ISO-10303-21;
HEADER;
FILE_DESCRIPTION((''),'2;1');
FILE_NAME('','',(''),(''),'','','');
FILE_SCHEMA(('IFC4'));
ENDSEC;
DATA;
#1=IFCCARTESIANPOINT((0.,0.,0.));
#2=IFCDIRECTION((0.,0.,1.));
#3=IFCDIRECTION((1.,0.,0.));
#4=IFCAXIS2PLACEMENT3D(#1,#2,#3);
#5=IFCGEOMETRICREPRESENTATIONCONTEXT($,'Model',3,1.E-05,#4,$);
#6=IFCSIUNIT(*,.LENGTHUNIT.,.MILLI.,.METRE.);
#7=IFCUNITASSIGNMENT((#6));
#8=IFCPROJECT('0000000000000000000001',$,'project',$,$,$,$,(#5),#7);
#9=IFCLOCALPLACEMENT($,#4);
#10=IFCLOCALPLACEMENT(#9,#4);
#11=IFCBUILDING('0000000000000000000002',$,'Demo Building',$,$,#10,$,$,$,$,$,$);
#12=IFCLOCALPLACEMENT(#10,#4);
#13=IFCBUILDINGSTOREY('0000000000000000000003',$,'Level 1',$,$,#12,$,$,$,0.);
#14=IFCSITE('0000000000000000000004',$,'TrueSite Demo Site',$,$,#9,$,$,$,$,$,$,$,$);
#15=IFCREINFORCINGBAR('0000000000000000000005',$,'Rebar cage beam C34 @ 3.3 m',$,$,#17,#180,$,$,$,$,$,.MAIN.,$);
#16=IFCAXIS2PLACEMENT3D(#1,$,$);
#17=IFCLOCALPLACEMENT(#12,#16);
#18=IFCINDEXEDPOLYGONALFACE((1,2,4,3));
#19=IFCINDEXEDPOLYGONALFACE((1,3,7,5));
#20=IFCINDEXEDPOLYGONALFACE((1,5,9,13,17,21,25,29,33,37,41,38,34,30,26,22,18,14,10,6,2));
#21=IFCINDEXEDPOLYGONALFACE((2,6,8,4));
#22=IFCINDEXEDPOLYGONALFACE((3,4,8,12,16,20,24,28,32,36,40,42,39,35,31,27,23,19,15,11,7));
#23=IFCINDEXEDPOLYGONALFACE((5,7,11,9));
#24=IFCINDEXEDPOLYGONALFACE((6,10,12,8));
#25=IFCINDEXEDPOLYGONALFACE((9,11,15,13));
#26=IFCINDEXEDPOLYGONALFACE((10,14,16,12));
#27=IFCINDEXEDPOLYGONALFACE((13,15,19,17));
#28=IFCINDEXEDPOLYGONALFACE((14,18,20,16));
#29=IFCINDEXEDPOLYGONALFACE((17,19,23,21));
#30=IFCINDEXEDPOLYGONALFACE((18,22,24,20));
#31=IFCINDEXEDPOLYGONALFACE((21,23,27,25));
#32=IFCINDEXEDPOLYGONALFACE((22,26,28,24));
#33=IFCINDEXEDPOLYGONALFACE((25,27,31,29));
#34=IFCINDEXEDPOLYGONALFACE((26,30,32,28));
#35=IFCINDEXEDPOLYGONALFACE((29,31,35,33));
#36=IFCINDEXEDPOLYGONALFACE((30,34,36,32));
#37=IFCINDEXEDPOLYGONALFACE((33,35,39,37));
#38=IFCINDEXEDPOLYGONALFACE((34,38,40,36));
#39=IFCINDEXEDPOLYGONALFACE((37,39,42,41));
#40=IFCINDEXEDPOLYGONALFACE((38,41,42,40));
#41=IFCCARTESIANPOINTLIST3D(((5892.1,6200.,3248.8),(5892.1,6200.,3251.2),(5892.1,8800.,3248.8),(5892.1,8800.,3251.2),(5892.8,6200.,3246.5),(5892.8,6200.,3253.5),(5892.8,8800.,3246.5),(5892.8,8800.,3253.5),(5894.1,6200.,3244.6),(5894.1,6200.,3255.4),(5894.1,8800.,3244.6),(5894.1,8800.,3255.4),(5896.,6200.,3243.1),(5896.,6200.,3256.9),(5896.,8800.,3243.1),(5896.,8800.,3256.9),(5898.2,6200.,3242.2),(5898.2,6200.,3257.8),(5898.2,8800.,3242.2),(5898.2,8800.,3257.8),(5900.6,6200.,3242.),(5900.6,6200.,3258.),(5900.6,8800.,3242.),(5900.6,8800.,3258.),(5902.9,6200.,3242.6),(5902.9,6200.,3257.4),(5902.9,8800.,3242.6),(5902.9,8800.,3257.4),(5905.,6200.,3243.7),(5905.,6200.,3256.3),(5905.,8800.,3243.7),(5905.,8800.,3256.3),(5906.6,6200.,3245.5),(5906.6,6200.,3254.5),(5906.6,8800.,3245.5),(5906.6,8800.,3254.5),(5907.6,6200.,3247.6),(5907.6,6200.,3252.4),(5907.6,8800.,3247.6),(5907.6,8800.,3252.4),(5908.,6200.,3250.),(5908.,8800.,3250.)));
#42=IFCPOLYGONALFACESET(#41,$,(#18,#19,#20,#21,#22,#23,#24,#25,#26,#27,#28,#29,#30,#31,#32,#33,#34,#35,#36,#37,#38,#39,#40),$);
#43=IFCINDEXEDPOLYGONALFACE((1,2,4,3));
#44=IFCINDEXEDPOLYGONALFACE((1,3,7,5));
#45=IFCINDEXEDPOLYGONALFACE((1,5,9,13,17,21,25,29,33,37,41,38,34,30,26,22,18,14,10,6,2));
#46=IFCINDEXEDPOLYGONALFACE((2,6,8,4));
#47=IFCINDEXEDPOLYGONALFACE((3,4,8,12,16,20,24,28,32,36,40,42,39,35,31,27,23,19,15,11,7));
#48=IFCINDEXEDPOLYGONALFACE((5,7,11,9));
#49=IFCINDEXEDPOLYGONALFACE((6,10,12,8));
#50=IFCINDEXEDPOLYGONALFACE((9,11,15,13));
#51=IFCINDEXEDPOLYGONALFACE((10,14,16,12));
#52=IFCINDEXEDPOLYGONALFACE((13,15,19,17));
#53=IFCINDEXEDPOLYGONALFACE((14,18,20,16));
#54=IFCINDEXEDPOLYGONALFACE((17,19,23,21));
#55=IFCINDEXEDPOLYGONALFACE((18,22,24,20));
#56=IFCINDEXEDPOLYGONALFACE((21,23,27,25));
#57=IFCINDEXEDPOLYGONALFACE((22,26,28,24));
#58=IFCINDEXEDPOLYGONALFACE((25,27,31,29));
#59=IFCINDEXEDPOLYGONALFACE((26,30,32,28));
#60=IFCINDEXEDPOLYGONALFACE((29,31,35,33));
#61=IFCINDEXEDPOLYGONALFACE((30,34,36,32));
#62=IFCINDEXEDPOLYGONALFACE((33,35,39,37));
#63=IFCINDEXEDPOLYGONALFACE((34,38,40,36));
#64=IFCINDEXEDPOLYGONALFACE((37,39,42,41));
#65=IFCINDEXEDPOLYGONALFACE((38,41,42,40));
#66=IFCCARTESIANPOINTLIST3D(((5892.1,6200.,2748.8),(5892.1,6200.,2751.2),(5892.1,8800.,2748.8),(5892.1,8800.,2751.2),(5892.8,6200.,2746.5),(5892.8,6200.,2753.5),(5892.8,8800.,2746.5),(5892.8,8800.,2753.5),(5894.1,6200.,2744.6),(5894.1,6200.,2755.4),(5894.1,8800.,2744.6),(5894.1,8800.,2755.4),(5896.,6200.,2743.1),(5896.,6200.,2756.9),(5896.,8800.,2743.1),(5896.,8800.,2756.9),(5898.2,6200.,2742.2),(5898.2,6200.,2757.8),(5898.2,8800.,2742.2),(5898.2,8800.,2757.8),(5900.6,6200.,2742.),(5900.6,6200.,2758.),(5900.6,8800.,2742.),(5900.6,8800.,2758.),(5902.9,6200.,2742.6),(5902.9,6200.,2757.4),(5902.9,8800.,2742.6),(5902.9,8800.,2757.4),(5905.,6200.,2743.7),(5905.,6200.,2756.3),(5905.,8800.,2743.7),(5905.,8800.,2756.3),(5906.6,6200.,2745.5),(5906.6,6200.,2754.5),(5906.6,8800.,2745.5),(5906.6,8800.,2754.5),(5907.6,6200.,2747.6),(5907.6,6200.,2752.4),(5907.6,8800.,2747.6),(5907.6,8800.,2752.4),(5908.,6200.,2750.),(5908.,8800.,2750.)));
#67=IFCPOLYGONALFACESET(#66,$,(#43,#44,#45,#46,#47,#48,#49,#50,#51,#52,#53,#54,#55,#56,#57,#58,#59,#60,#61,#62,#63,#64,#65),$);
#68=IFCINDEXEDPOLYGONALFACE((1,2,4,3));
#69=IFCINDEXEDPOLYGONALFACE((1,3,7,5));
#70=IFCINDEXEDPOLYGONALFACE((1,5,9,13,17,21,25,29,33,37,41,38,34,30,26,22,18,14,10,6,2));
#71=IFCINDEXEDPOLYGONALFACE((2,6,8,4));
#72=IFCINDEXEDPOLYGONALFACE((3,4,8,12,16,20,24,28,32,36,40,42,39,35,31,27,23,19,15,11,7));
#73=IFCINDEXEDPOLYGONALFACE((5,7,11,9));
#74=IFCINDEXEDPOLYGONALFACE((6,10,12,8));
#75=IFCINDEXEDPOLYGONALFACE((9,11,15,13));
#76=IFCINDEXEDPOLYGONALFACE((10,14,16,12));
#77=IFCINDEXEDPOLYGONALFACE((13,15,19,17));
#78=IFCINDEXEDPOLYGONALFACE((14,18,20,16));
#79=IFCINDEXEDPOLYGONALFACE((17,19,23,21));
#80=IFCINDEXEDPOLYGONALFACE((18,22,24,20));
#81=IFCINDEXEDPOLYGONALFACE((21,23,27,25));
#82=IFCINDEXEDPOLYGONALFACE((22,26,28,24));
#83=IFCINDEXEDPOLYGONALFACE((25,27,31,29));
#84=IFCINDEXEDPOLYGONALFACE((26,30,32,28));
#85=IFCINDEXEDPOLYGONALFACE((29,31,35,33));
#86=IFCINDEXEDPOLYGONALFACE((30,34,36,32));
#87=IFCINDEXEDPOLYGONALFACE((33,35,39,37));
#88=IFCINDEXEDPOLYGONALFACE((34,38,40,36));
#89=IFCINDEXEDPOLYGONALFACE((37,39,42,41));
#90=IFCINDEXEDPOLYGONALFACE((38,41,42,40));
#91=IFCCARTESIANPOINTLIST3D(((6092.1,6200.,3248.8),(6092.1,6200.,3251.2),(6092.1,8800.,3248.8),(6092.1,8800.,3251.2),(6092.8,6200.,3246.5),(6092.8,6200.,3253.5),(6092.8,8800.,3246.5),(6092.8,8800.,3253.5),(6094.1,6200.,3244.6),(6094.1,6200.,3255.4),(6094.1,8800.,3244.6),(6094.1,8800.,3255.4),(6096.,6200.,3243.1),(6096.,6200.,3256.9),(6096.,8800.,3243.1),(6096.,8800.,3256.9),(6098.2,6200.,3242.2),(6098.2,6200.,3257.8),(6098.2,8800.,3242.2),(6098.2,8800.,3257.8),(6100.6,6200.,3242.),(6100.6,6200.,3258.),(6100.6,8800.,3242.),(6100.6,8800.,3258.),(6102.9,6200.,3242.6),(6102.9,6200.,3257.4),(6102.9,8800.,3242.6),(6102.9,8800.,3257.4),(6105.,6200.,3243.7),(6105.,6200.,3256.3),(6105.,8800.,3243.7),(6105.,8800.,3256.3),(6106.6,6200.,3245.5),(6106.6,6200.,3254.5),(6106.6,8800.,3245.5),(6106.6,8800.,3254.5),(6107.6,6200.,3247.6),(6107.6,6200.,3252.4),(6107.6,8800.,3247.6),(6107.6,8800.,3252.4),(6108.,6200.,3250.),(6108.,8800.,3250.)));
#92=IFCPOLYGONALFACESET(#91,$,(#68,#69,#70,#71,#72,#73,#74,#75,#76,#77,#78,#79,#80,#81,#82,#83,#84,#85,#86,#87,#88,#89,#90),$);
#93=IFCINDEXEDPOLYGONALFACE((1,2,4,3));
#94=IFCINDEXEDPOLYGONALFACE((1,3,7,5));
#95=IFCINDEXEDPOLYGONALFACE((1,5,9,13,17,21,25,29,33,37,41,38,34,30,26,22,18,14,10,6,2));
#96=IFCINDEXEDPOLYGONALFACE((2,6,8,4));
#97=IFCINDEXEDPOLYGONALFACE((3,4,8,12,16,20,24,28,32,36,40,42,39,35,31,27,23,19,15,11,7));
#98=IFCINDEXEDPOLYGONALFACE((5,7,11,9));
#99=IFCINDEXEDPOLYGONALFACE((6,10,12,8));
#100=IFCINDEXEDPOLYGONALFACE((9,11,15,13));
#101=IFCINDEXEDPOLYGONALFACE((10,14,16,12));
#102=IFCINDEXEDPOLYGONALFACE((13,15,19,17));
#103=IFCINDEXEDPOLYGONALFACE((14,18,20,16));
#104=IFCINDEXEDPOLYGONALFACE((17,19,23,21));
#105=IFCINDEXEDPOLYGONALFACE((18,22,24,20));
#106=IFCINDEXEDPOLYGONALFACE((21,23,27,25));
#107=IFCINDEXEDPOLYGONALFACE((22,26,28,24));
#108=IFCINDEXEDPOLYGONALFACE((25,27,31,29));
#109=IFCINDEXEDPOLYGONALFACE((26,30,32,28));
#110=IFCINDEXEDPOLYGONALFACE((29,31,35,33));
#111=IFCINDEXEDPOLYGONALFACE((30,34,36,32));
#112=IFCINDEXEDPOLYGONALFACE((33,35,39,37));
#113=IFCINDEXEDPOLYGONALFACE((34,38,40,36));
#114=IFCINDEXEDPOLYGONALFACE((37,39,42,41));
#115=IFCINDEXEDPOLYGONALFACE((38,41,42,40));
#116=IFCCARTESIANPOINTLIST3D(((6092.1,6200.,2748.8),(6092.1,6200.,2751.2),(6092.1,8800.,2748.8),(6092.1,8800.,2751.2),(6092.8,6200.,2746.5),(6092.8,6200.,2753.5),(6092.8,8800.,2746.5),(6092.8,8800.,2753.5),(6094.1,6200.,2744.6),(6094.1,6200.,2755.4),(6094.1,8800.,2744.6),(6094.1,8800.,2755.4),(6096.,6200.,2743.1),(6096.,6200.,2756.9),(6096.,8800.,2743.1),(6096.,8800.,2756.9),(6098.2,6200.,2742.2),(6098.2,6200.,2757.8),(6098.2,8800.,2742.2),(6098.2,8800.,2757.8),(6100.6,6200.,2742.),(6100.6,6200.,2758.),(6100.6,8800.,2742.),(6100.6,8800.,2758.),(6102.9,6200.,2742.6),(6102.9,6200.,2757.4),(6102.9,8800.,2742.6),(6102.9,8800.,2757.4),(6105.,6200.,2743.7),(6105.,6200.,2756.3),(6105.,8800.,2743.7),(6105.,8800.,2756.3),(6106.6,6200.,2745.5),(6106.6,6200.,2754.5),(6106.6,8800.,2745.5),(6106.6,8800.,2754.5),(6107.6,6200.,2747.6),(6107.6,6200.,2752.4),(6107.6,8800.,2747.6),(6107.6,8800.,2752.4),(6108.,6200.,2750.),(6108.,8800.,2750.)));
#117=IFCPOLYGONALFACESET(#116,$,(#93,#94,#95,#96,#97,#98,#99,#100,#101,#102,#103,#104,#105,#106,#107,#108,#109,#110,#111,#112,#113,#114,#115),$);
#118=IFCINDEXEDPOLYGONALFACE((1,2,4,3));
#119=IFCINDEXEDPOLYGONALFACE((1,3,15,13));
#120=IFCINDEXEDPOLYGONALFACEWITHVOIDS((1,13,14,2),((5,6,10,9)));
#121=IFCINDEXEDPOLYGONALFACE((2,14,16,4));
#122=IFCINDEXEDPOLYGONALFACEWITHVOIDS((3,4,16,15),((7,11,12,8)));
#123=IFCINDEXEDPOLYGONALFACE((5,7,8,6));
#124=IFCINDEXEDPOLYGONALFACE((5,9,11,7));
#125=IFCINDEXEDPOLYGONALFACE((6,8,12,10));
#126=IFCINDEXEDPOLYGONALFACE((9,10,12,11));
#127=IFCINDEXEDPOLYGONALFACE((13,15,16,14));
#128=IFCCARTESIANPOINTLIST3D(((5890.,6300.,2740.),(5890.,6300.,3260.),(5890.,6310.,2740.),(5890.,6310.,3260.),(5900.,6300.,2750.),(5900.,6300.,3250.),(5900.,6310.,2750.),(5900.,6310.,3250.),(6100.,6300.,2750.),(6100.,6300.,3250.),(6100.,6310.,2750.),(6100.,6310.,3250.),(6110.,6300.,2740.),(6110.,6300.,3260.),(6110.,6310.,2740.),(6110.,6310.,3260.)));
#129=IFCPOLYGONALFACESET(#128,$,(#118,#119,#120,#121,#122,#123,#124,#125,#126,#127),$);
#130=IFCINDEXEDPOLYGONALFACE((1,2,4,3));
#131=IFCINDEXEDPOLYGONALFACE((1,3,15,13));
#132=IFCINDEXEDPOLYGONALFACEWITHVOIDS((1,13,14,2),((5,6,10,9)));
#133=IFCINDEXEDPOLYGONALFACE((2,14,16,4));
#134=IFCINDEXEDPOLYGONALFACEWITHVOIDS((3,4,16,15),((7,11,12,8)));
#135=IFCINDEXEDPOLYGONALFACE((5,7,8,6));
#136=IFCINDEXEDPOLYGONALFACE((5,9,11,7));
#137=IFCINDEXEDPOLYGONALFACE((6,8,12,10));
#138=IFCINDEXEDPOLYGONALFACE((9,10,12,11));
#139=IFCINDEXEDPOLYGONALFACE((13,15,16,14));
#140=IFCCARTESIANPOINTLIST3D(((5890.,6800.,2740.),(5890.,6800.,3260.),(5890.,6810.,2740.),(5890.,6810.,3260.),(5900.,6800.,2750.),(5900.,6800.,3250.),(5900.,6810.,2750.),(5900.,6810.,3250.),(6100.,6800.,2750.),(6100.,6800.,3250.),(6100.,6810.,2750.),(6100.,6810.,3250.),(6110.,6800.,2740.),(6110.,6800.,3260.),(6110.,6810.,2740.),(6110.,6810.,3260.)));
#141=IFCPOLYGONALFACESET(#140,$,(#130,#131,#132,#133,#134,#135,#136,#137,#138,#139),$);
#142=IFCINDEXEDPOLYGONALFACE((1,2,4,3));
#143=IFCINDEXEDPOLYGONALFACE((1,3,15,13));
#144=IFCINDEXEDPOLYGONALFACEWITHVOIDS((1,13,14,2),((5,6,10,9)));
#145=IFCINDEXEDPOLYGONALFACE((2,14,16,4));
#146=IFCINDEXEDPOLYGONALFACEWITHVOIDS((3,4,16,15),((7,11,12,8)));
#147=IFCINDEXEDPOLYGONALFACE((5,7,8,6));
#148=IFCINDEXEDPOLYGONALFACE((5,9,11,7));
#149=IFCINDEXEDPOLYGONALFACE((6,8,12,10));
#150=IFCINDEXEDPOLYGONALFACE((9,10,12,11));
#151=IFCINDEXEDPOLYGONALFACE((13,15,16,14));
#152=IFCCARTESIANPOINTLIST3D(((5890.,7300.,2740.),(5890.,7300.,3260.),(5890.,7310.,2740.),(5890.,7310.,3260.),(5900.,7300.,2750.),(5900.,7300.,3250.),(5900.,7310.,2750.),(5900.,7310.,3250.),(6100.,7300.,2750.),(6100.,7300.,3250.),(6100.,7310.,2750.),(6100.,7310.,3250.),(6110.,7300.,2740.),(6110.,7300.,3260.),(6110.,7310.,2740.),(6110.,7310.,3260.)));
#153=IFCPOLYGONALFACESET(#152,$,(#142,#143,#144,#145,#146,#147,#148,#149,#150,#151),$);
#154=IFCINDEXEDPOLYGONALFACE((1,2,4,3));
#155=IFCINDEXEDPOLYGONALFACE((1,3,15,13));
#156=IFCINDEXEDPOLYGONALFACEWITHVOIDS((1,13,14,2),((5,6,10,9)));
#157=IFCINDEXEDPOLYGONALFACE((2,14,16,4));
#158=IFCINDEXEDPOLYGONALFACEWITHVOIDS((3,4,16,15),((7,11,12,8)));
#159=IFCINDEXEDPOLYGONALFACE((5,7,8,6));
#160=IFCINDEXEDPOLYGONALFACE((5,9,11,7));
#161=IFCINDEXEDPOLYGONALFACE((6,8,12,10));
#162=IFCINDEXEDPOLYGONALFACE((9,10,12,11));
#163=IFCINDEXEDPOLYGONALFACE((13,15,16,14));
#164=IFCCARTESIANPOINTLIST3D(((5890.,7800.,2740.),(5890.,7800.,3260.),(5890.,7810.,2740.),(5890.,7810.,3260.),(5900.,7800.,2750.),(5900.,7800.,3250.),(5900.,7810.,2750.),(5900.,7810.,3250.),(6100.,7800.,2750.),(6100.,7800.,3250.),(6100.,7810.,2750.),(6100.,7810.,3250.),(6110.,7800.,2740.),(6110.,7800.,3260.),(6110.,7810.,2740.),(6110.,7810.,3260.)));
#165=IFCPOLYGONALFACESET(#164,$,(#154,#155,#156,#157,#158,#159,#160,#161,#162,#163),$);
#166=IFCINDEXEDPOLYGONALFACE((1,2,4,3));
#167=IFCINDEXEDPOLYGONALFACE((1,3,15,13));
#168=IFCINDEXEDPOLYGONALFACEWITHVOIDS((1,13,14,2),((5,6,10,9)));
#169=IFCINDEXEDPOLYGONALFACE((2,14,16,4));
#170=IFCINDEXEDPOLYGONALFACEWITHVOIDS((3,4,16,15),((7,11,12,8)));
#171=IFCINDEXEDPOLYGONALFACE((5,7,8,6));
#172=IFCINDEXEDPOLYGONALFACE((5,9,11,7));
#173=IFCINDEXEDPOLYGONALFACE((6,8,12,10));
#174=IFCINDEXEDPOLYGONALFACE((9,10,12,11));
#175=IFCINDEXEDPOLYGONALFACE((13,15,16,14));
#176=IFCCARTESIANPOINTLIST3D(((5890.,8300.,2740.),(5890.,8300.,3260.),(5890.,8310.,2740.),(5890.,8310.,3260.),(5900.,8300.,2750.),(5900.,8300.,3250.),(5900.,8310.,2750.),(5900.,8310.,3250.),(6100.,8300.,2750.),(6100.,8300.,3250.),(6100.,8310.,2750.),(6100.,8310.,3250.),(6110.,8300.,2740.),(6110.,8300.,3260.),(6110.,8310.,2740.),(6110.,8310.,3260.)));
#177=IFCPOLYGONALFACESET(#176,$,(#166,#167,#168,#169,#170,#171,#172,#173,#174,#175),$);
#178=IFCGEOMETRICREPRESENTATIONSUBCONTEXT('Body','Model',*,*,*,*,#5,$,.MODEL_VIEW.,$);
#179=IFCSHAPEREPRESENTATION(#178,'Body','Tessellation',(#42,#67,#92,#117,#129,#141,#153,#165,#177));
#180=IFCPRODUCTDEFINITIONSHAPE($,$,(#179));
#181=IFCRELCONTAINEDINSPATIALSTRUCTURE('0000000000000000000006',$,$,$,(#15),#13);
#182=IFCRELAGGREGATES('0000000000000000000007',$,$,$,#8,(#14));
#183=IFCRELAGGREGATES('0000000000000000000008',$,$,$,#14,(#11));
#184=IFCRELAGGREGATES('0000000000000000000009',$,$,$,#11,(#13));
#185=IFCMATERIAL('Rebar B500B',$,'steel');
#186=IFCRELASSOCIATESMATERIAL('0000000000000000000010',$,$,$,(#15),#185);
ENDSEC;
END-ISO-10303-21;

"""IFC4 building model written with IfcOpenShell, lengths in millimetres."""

from ifc_helpers import new_model, si_unit, frame, origin_with_axes, place, context, subcontext, project, spatial, hollow_rectangle, circle, extrude, material, element, save


model = new_model("IFC4")

# Units and contexts
model_context = context("Model", 3, precision=1e-05, world=origin_with_axes())
body_context = subcontext(model_context, "Body", "Model", "MODEL_VIEW")
ifc_project = project(units=[si_unit("LENGTHUNIT", "METRE", prefix="MILLI")], contexts=[model_context])

# Site, building, storey
site_placement = place(None, origin_with_axes())
site = spatial("IfcSite", under=ifc_project, at=site_placement, Name="TrueSite Demo Site")
building_placement = place(site_placement, origin_with_axes())
building = spatial("IfcBuilding", under=site, at=building_placement, Name="Demo Building")
storey_placement = place(building_placement, origin_with_axes())
storey = spatial("IfcBuildingStorey", under=building, at=storey_placement, Name="Level 1", Elevation=0.0)

# Reinforcing bar
ifc_material_1 = material(Name="Rebar B500B", Category="steel")
for number, where, z_axis, x_axis, name in (
    (1, (6000.0, 6200.0, 3000.0), (0.0, 1.0, 0.0), (1.0, 0.0, 0.0), "Rebar cage beam C34 @ 3.3 m"),
):
    element("IfcReinforcingBar", number, at=place(storey_placement, frame(where, z_axis=z_axis, x_axis=x_axis)), inside=storey, material=ifc_material_1, Name=name, PredefinedType="MAIN", context=body_context, shape_type="SweptSolid", body=[
        extrude(circle(Radius=8.0), frame((-100.0, -250.0, 0.0)), (0.0, 0.0, 1.0), 2600.0),
        extrude(circle(Radius=8.0), frame((-100.0, 250.0, 0.0)), (0.0, 0.0, 1.0), 2600.0),
        extrude(circle(Radius=8.0), frame((100.0, -250.0, 0.0)), (0.0, 0.0, 1.0), 2600.0),
        extrude(circle(Radius=8.0), frame((100.0, 250.0, 0.0)), (0.0, 0.0, 1.0), 2600.0),
        extrude(hollow_rectangle(XDim=220.0, YDim=520.0, WallThickness=10.0), frame((0.0, 0.0, 100.0)), (0.0, 0.0, 1.0), 10.0),
        extrude(hollow_rectangle(XDim=220.0, YDim=520.0, WallThickness=10.0), frame((0.0, 0.0, 600.0)), (0.0, 0.0, 1.0), 10.0),
        extrude(hollow_rectangle(XDim=220.0, YDim=520.0, WallThickness=10.0), frame((0.0, 0.0, 1100.0)), (0.0, 0.0, 1.0), 10.0),
        extrude(hollow_rectangle(XDim=220.0, YDim=520.0, WallThickness=10.0), frame((0.0, 0.0, 1600.0)), (0.0, 0.0, 1.0), 10.0),
        extrude(hollow_rectangle(XDim=220.0, YDim=520.0, WallThickness=10.0), frame((0.0, 0.0, 2100.0)), (0.0, 0.0, 1.0), 10.0),
    ])

save(model, "model.ifc")
